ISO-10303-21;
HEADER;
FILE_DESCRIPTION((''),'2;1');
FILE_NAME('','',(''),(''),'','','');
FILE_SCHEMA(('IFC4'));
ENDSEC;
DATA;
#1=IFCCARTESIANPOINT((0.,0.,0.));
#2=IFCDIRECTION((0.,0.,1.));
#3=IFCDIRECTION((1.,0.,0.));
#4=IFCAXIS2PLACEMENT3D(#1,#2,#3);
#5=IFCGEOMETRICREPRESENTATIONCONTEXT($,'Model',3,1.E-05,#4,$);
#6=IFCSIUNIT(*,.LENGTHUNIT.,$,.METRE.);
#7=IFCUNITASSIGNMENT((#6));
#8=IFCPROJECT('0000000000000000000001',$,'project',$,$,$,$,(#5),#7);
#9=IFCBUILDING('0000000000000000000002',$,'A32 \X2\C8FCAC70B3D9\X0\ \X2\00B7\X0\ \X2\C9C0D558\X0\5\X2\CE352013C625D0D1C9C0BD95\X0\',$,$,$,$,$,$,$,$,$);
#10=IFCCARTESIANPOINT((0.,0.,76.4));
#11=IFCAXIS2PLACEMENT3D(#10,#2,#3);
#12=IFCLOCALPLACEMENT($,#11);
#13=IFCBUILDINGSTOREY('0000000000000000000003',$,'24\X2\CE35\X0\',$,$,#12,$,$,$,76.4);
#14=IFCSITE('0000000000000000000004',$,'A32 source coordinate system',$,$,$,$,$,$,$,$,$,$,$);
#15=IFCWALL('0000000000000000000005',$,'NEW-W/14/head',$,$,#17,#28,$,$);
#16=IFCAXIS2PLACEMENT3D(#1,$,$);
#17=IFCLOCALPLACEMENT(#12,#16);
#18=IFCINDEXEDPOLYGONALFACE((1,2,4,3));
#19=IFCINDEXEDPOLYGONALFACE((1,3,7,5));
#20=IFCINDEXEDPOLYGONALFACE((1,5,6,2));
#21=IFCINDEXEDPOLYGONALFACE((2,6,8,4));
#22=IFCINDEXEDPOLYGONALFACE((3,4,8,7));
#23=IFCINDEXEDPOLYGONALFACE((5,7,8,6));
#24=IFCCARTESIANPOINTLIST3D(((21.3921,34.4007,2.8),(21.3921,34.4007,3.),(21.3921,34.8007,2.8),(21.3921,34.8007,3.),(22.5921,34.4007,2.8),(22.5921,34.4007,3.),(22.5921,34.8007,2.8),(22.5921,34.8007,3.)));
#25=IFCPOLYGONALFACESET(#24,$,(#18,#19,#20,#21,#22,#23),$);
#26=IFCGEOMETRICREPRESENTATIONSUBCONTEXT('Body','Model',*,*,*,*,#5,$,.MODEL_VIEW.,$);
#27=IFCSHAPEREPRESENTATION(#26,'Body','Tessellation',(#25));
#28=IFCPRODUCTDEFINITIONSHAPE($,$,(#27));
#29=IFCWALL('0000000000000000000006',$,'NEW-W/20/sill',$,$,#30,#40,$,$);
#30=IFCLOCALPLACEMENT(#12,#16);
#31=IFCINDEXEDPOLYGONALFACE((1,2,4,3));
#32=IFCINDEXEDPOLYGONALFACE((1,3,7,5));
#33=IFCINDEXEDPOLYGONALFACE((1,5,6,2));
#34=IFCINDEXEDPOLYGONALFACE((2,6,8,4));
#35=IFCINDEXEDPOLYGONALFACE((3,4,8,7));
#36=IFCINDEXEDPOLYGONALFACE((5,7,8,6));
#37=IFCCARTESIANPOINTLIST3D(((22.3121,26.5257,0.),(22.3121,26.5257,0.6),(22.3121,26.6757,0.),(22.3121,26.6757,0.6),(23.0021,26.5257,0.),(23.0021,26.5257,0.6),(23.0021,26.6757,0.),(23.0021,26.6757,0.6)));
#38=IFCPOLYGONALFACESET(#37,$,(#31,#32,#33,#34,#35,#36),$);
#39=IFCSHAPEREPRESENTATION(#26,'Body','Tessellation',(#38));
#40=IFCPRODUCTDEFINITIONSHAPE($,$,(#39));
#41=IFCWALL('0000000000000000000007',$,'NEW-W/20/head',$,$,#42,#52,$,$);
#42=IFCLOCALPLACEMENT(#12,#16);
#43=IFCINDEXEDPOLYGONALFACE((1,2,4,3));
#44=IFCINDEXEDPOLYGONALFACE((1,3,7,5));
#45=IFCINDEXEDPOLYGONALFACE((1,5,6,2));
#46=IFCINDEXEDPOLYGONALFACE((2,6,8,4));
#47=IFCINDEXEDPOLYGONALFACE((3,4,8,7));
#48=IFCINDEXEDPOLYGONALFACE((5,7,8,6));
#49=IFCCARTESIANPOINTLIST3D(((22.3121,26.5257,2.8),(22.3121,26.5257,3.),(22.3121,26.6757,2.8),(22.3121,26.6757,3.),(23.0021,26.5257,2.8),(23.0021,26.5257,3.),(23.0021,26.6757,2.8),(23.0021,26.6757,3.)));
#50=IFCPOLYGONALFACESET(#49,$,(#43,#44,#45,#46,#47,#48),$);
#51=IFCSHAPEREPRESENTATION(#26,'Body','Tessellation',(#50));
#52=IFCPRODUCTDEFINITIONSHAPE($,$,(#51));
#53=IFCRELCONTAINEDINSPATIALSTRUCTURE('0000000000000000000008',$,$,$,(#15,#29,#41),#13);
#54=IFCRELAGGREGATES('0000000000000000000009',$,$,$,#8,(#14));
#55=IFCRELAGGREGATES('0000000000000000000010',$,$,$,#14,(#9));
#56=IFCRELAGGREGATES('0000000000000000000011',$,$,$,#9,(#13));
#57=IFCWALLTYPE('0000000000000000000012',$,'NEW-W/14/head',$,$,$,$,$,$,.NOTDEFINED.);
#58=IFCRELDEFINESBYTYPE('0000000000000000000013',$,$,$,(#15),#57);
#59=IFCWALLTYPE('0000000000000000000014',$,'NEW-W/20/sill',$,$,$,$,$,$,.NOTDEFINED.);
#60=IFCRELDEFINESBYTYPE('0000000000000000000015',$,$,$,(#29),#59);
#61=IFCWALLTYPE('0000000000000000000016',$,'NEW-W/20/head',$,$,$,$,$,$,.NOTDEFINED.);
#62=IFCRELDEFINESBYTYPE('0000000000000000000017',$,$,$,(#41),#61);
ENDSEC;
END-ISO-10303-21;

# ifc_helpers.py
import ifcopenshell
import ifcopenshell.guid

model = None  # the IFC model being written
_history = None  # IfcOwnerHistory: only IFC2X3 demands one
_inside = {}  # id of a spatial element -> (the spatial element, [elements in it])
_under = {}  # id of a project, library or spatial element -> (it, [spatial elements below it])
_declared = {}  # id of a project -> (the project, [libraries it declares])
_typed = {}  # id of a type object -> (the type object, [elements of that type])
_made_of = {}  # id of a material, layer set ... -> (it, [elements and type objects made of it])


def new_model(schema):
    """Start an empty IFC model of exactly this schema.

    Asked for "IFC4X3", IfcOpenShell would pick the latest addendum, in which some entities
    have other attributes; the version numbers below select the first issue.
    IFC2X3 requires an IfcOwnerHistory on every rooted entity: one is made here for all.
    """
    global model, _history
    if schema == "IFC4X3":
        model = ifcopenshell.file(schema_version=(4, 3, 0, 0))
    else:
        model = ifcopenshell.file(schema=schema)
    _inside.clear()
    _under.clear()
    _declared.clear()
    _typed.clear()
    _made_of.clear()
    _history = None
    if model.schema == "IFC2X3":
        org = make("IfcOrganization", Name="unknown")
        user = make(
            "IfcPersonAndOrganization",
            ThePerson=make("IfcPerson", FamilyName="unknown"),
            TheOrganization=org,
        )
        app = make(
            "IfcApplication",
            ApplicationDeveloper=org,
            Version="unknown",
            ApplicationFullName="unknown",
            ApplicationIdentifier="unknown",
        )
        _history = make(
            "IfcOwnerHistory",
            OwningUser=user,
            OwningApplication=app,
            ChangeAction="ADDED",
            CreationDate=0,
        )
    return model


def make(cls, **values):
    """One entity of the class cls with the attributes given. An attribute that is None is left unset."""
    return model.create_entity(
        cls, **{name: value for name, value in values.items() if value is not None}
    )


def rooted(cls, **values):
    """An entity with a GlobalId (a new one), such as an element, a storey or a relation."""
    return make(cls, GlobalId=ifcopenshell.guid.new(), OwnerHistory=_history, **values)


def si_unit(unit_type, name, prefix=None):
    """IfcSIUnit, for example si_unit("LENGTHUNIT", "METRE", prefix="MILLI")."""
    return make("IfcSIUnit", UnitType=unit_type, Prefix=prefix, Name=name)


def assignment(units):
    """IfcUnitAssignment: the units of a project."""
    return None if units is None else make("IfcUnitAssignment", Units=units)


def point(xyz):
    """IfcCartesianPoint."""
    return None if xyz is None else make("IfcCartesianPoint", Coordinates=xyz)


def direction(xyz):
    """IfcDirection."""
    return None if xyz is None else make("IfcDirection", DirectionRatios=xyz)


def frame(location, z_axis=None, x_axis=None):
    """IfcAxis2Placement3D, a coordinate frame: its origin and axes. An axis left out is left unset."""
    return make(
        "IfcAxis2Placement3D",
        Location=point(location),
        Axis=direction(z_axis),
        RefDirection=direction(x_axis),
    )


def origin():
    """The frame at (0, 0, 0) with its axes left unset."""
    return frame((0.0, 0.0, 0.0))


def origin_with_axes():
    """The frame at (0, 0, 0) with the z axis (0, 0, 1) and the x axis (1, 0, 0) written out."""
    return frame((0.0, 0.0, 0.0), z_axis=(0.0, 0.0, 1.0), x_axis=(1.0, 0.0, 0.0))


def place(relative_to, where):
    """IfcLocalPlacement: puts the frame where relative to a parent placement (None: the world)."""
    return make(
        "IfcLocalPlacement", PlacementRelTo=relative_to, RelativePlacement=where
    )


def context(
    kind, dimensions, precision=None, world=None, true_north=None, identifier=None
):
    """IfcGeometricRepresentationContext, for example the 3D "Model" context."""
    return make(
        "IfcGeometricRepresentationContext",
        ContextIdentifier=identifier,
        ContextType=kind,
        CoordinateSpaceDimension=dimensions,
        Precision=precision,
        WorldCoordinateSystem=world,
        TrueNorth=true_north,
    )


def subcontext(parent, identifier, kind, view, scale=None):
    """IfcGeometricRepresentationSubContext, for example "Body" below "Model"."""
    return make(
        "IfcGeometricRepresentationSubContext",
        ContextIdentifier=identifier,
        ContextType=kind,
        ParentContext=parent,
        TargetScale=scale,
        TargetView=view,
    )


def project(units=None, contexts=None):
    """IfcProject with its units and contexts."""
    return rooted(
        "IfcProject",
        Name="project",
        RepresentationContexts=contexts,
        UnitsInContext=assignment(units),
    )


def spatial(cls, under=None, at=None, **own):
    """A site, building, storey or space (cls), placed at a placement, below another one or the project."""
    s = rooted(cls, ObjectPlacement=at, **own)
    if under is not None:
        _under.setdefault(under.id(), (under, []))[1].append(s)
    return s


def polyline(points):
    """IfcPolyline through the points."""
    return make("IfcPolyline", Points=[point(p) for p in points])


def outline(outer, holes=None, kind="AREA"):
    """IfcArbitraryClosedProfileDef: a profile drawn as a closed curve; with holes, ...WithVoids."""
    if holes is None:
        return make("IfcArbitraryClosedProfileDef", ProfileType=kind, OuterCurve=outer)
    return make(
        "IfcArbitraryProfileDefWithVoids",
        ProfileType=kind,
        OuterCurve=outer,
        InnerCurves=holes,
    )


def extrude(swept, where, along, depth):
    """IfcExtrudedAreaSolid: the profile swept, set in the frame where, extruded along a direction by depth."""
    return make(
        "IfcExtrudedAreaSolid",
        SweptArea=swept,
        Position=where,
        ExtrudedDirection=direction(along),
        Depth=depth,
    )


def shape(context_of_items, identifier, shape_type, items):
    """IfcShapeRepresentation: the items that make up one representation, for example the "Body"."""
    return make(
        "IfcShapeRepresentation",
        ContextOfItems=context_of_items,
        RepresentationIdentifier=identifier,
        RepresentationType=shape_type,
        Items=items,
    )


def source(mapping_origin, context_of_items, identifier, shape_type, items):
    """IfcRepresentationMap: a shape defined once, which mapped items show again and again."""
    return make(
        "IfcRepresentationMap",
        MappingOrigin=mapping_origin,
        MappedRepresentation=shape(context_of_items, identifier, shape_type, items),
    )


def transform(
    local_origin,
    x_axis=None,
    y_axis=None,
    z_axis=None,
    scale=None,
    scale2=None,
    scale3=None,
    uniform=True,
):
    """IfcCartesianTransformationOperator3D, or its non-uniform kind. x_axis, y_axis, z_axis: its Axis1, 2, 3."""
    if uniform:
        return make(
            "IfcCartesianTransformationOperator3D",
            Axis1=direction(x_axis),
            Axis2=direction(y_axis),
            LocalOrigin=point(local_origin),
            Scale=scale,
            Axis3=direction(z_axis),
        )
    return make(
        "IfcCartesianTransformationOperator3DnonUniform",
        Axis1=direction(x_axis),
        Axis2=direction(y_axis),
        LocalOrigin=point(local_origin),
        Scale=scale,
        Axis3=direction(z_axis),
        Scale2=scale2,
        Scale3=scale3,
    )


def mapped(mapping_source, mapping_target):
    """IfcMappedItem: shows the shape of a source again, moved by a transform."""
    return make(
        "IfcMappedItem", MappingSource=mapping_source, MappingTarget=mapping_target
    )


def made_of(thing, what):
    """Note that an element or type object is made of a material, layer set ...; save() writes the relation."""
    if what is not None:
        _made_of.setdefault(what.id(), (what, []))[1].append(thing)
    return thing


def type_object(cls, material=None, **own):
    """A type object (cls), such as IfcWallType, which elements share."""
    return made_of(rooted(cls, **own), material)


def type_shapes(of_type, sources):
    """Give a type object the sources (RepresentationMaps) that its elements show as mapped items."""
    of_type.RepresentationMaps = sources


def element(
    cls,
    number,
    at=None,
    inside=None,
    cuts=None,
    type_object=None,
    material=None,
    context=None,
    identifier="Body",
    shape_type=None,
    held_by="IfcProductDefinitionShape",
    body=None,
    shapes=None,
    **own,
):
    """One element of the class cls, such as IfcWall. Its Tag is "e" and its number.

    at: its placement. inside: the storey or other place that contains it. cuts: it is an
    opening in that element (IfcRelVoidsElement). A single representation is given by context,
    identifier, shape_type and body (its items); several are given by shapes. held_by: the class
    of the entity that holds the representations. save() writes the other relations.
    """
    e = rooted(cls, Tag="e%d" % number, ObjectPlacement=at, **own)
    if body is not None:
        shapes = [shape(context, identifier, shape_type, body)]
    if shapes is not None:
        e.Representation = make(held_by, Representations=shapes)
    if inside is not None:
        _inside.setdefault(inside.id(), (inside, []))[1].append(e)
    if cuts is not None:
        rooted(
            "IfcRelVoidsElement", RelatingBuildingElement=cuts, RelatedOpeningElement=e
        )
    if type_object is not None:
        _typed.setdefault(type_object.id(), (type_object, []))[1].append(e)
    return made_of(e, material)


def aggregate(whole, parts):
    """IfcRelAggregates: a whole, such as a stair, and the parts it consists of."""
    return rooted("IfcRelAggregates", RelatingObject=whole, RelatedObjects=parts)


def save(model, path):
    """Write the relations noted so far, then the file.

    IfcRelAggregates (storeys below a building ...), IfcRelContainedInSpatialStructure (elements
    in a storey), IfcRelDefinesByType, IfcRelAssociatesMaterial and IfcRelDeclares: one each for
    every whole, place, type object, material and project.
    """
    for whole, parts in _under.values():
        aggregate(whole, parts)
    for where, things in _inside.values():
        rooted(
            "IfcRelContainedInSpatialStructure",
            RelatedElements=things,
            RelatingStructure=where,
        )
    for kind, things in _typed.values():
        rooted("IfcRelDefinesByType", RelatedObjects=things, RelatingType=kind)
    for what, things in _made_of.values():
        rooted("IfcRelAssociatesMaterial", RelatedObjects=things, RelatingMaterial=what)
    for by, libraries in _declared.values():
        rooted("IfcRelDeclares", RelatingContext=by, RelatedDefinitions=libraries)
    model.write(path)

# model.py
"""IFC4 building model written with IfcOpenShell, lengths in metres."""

from ifc_helpers import new_model, si_unit, frame, origin, origin_with_axes, place, context, subcontext, project, spatial, polyline, outline, extrude, source, transform, mapped, type_object, type_shapes, element, save


model = new_model("IFC4")

# Units and contexts
model_context = context("Model", 3, precision=1e-05, world=origin_with_axes())
body_context = subcontext(model_context, "Body", "Model", "MODEL_VIEW")
ifc_project = project(units=[si_unit("LENGTHUNIT", "METRE")], contexts=[model_context])

# Site, building, storey
site = spatial("IfcSite", under=ifc_project, Name="A32 source coordinate system")
building = spatial("IfcBuilding", under=site, Name="A32 주거동 · 지하5층–옥탑지붕")
storey_placement = place(None, frame((0.0, 0.0, 76.4), z_axis=(0.0, 0.0, 1.0), x_axis=(1.0, 0.0, 0.0)))
storey = spatial("IfcBuildingStorey", under=building, at=storey_placement, Name="24층", Elevation=76.4)

# Walls
wall_type_1 = type_object("IfcWallType", Name="NEW-W/14/head", PredefinedType="NOTDEFINED")
shared_shape_1 = source(origin(), body_context, "Body", "SweptSolid", [
    extrude(outline(polyline([(21.3921, 34.4007), (21.3921, 34.8007), (22.5921, 34.8007), (22.5921, 34.4007), (21.3921, 34.4007)])), frame((0.0, 0.0, 2.8)), (0.0, 0.0, 1.0), 0.2),
])
type_shapes(wall_type_1, [shared_shape_1])
wall_1_placement = place(storey_placement, origin_with_axes())
element("IfcWall", 1, at=wall_1_placement, inside=storey, type_object=wall_type_1, Name="NEW-W/14/head", context=body_context, shape_type="MappedRepresentation", body=[
    mapped(shared_shape_1, transform((0.0, 0.0, 0.0), scale=1.0)),
])
wall_type_2 = type_object("IfcWallType", Name="NEW-W/20/sill", PredefinedType="NOTDEFINED")
shared_shape_2 = source(origin(), body_context, "Body", "SweptSolid", [
    extrude(outline(polyline([(22.3121, 26.5257), (22.3121, 26.6757), (23.0021, 26.6757), (23.0021, 26.5257), (22.3121, 26.5257)])), origin(), (0.0, 0.0, 1.0), 0.6),
])
type_shapes(wall_type_2, [shared_shape_2])
wall_2_placement = place(storey_placement, origin_with_axes())
element("IfcWall", 2, at=wall_2_placement, inside=storey, type_object=wall_type_2, Name="NEW-W/20/sill", context=body_context, shape_type="MappedRepresentation", body=[
    mapped(shared_shape_2, transform((0.0, 0.0, 0.0), scale=1.0)),
])
wall_type_3 = type_object("IfcWallType", Name="NEW-W/20/head", PredefinedType="NOTDEFINED")
shared_shape_3 = source(origin(), body_context, "Body", "SweptSolid", [
    extrude(outline(polyline([(22.3121, 26.5257), (22.3121, 26.6757), (23.0021, 26.6757), (23.0021, 26.5257), (22.3121, 26.5257)])), frame((0.0, 0.0, 2.8)), (0.0, 0.0, 1.0), 0.2),
])
type_shapes(wall_type_3, [shared_shape_3])
wall_3_placement = place(storey_placement, origin_with_axes())
element("IfcWall", 3, at=wall_3_placement, inside=storey, type_object=wall_type_3, Name="NEW-W/20/head", context=body_context, shape_type="MappedRepresentation", body=[
    mapped(shared_shape_3, transform((0.0, 0.0, 0.0), scale=1.0)),
])

save(model, "model.ifc")
